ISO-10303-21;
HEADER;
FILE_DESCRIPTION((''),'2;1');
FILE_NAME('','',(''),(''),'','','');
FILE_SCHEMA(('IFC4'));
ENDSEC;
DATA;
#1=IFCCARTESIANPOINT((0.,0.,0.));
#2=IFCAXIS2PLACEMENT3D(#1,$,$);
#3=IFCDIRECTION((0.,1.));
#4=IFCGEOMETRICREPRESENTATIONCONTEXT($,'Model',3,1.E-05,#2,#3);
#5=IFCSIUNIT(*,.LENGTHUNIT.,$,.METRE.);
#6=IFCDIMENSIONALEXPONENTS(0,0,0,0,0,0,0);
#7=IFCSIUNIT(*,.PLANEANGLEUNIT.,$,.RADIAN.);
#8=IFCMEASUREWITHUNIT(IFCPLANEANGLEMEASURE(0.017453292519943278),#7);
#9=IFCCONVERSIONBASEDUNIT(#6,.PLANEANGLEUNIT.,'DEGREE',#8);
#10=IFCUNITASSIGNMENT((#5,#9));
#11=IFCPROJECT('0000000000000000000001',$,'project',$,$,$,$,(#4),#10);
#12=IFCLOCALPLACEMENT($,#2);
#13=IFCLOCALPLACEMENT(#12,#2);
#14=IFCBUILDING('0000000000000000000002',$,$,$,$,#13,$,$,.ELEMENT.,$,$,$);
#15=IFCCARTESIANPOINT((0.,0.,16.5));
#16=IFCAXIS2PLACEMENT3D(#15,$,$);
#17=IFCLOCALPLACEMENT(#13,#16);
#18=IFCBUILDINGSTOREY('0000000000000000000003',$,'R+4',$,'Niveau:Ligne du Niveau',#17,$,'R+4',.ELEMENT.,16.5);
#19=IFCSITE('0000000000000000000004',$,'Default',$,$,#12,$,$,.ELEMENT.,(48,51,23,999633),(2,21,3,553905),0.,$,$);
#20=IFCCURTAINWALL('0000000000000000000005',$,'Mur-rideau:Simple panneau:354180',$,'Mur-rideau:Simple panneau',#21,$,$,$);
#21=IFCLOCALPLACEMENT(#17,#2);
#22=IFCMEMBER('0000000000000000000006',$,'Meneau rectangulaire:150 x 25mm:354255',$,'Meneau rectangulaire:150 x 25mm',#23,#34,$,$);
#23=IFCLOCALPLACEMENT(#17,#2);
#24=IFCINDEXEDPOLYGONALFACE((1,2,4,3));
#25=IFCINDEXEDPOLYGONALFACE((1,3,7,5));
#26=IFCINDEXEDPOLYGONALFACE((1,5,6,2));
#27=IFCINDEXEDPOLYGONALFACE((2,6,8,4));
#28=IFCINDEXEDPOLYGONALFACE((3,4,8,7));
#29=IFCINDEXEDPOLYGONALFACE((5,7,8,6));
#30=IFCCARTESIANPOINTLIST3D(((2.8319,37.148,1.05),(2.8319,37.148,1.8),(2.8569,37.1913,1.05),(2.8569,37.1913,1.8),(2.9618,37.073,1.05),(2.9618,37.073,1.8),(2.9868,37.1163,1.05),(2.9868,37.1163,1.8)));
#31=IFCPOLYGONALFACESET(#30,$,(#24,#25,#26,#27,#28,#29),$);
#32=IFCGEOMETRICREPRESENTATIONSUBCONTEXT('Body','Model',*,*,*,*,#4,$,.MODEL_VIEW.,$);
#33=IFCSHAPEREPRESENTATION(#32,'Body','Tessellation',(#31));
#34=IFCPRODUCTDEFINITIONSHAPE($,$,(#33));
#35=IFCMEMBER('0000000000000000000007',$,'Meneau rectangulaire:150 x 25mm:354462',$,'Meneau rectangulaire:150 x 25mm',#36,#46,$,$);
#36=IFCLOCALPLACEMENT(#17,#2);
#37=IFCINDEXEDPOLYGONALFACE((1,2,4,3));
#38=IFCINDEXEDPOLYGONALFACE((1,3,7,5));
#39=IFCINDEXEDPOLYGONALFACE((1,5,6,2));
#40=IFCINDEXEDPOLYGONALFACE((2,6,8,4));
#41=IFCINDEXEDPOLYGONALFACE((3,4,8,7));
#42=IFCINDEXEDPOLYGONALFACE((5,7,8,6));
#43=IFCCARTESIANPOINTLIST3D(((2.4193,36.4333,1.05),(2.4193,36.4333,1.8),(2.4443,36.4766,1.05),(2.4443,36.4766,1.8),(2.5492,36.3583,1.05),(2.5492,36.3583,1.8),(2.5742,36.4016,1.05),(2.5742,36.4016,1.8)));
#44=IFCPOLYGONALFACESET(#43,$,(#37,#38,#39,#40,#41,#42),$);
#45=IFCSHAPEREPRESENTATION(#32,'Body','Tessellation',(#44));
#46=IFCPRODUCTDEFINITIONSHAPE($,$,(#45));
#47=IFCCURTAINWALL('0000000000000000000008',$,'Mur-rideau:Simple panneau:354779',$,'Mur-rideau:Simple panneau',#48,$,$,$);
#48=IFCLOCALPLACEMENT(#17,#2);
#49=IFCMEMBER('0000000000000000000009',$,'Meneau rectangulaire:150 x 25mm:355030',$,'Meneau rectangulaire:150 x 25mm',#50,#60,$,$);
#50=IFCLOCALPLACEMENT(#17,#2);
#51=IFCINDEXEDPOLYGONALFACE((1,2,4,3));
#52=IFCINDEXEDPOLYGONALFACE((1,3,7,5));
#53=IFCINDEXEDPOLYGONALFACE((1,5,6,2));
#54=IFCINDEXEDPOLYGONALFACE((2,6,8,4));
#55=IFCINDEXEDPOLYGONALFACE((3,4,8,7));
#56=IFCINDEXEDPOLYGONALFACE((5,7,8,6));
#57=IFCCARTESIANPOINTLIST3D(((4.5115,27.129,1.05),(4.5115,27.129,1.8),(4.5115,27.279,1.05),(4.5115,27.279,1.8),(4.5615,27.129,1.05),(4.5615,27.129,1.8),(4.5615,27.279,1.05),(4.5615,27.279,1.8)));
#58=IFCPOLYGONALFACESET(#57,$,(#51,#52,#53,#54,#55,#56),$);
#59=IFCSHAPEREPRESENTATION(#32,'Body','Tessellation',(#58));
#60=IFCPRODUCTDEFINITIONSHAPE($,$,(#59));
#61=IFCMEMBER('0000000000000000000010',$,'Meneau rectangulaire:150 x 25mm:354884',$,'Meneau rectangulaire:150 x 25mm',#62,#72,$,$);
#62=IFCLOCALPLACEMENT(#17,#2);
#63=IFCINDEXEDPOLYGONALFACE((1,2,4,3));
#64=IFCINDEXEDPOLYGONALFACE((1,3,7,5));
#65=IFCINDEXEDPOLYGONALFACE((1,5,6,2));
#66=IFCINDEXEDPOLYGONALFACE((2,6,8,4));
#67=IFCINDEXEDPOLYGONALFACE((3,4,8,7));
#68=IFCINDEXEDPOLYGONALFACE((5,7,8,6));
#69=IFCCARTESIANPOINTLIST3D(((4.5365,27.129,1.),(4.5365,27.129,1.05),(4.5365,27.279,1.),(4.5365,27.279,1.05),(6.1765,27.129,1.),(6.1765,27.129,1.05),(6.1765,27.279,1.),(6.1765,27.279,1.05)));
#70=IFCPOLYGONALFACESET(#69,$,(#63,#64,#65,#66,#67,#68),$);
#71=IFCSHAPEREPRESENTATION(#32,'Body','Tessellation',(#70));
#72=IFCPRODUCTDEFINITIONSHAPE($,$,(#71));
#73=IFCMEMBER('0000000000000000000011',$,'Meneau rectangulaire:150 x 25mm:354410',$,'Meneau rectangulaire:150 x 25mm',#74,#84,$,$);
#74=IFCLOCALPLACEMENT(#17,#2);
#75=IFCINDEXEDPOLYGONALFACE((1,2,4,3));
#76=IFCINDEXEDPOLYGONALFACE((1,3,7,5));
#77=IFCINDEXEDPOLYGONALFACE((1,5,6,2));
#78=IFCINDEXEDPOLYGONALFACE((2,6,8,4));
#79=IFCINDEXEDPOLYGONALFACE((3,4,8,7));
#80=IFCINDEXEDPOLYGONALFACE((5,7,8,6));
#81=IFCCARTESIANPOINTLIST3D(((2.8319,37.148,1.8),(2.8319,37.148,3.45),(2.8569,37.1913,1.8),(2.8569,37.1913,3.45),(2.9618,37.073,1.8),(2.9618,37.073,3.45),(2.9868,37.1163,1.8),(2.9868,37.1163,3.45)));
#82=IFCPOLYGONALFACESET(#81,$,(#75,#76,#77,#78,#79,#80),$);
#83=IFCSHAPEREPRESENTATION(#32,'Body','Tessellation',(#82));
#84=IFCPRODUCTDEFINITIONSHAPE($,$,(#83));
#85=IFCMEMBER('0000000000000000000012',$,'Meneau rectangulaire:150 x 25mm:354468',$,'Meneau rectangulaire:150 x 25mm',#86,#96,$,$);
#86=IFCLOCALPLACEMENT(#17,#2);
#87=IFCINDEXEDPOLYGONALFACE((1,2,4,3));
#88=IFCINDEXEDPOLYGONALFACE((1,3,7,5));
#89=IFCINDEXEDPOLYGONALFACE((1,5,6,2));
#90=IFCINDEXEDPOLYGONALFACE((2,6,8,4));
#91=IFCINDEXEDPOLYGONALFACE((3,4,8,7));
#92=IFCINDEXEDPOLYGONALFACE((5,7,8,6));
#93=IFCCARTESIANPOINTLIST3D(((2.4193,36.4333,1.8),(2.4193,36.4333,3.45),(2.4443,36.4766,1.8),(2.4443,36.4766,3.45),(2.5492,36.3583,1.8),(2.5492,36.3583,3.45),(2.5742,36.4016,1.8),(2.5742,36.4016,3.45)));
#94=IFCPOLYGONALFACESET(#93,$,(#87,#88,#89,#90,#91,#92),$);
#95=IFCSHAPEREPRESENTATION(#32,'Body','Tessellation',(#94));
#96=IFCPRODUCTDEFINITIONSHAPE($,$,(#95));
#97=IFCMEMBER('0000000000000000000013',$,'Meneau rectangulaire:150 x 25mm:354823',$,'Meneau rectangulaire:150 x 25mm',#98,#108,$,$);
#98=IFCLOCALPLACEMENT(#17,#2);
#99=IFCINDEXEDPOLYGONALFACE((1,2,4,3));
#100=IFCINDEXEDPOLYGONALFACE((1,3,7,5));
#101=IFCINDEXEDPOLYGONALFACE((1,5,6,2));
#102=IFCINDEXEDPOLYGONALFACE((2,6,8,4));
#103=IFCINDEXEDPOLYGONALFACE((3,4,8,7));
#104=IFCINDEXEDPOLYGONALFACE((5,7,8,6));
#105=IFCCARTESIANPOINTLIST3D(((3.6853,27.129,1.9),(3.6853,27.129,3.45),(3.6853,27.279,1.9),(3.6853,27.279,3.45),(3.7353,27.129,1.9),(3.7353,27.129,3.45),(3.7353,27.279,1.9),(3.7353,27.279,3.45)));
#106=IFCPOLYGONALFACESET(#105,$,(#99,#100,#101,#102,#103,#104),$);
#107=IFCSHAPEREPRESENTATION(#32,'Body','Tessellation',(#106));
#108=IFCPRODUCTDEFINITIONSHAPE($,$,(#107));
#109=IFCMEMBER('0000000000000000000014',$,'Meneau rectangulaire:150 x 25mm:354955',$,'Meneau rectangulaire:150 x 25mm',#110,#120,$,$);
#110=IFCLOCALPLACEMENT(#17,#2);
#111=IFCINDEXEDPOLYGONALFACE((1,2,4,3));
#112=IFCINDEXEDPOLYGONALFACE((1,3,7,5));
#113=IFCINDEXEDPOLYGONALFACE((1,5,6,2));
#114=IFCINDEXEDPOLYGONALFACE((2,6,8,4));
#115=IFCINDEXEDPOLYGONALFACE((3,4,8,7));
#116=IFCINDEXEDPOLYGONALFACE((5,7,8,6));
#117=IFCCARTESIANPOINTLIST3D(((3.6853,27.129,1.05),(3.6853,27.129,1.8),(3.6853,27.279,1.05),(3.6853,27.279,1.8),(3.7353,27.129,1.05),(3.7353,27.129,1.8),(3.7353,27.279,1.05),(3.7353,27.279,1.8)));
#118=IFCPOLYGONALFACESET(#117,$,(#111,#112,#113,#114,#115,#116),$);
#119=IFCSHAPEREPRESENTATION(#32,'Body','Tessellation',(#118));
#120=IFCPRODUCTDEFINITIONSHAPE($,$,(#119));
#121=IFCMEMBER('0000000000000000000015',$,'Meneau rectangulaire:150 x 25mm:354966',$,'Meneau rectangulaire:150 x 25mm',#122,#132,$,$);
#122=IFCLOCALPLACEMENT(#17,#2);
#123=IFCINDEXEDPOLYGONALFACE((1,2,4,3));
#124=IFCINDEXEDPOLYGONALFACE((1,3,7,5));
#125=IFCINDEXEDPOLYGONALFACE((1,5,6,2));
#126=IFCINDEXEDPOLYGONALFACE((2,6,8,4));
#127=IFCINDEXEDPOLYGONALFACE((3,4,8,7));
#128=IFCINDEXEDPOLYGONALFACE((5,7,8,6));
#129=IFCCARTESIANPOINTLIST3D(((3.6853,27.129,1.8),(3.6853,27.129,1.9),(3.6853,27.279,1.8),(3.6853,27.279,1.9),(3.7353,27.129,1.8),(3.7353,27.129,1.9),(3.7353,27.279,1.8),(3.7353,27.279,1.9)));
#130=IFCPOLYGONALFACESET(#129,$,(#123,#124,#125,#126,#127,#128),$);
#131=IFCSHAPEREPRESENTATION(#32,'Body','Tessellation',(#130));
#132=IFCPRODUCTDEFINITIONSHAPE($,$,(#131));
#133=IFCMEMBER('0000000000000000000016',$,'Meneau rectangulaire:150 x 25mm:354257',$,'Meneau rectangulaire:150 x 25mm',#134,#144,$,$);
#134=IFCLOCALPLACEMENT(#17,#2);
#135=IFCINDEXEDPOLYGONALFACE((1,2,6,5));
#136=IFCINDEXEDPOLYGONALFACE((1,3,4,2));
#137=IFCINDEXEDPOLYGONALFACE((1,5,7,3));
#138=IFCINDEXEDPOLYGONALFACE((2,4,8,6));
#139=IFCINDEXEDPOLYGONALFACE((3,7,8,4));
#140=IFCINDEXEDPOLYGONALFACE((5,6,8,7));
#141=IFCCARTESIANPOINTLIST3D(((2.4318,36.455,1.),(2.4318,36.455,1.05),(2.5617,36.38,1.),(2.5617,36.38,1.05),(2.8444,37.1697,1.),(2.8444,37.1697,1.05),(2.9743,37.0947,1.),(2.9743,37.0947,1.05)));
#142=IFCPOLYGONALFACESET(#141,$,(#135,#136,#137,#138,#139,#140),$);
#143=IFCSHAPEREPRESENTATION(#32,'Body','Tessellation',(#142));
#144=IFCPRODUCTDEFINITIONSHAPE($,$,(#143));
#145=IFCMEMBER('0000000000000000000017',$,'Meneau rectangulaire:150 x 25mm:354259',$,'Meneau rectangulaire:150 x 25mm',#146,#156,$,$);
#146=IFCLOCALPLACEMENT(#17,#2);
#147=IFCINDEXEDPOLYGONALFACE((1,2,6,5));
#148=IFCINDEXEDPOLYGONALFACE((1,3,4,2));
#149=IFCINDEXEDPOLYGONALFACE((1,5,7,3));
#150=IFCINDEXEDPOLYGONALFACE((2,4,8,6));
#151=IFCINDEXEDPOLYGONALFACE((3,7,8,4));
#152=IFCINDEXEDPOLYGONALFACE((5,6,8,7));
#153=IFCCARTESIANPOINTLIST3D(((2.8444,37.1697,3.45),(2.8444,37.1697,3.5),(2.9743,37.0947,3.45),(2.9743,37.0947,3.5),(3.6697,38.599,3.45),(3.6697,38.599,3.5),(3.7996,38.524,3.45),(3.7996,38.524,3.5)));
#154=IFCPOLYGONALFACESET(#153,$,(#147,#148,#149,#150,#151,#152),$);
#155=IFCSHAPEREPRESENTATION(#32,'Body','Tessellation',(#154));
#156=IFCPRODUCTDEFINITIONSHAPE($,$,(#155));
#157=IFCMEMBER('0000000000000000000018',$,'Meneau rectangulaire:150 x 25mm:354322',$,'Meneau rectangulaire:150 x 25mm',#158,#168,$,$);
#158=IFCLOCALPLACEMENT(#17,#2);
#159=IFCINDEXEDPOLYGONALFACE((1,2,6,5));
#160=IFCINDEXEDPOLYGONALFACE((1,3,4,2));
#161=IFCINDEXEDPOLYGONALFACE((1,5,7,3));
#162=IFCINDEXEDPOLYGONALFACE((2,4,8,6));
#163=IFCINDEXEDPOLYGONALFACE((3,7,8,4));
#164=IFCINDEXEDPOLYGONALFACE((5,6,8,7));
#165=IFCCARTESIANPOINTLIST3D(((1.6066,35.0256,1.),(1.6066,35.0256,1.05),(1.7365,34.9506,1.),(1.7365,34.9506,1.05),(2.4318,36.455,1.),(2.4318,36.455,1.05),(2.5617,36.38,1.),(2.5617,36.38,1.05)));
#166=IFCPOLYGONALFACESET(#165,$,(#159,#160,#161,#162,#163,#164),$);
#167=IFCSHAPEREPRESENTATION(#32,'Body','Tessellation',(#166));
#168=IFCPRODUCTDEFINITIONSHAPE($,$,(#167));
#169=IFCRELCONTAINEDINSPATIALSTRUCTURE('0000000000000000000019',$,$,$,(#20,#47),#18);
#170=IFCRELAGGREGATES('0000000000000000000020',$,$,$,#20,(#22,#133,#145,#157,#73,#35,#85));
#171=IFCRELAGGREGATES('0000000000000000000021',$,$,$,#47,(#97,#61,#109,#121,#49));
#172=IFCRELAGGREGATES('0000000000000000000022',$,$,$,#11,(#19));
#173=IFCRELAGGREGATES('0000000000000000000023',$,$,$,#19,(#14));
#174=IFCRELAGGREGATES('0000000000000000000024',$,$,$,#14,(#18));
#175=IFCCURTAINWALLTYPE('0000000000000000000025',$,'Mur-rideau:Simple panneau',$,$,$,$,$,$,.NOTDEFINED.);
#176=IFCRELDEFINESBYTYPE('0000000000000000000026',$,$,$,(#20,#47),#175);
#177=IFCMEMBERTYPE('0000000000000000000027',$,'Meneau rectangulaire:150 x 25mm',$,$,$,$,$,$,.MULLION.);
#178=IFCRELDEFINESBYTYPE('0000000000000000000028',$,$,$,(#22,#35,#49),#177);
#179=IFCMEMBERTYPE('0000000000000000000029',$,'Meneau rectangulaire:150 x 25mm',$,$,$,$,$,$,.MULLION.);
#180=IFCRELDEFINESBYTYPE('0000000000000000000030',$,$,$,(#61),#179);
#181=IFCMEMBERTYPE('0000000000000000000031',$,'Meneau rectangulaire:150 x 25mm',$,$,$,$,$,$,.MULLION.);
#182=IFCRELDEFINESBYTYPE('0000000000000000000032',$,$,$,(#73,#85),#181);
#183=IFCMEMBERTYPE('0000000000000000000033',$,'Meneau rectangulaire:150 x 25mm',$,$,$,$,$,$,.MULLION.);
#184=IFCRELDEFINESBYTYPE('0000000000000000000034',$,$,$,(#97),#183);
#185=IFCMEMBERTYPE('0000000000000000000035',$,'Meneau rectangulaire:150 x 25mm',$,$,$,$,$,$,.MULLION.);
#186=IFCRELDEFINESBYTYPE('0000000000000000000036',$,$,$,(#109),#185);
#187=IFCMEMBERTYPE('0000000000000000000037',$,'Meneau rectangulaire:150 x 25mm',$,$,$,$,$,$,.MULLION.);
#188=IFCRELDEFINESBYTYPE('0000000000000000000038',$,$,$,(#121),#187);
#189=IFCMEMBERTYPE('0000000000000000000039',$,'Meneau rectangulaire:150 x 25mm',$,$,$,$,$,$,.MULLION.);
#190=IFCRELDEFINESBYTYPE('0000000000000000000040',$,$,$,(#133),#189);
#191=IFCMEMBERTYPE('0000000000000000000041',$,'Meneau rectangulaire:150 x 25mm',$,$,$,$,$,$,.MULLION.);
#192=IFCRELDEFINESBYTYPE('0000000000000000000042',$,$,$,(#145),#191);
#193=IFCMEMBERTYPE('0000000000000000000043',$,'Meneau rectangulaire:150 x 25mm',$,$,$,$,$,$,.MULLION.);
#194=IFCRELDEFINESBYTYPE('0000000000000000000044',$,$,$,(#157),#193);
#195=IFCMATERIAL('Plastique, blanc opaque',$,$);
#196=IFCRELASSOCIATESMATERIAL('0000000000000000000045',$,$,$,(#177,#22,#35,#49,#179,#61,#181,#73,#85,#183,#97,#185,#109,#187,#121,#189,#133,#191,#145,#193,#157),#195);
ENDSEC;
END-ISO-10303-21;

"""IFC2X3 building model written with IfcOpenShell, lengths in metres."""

from ifc_helpers import new_model, entity, si_unit, converted_unit, direction, frame, frame_2d, origin, origin_2d_with_axis, place, context, subcontext, project, spatial, rectangle, extrude, source, transform, mapped, material, type_object, type_shapes, element, aggregate, save


model = new_model("IFC2X3")

# Units and contexts
model_context = context("Model", 3, precision=1e-05, world=origin(), true_north=direction((0.0, 1.0)))
body_context = subcontext(model_context, "Body", "Model", "MODEL_VIEW")
ifc_project = project(units=[si_unit("LENGTHUNIT", "METRE"), converted_unit("PLANEANGLEUNIT", "DEGREE", entity("IfcPlaneAngleMeasure", 0.017453292519943278), si_unit("PLANEANGLEUNIT", "RADIAN"), dimensions=[0, 0, 0, 0, 0, 0, 0])], contexts=[model_context])

# Site, building, storey
site_placement = place(None, origin())
site = spatial("IfcSite", under=ifc_project, at=site_placement, Name="Default", CompositionType="ELEMENT", RefLatitude=(48, 51, 23, 999633), RefLongitude=(2, 21, 3, 553905), RefElevation=0.0)
building_placement = place(site_placement, origin())
building = spatial("IfcBuilding", under=site, at=building_placement, CompositionType="ELEMENT")
storey_placement = place(building_placement, frame((0.0, 0.0, 16.5)))
storey = spatial("IfcBuildingStorey", under=building, at=storey_placement, Name="R+4", ObjectType="Niveau:Ligne du Niveau", LongName="R+4", CompositionType="ELEMENT", Elevation=16.5)

# Curtain walls, members
curtain_wall_type = type_object("IfcCurtainWallType", Name="Mur-rideau:Simple panneau", PredefinedType="NOTDEFINED")
curtain_wall_1_placement = place(storey_placement, frame((0.0, 0.0, -16.5)))
curtain_wall_1 = element("IfcCurtainWall", 1, at=curtain_wall_1_placement, inside=storey, type_object=curtain_wall_type, Name="Mur-rideau:Simple panneau:354180", ObjectType="Mur-rideau:Simple panneau")
ifc_material_1 = material(Name="Plastique, blanc opaque")
member_type_1 = type_object("IfcMemberType", Name="Meneau rectangulaire:150 x 25mm", PredefinedType="MULLION", material=ifc_material_1)
shared_shape_1 = source(origin(), body_context, "Body", "SweptSolid", [
    extrude(rectangle(XDim=0.05, YDim=0.15, at=origin_2d_with_axis()), frame((0.0, 0.0, -0.75), z_axis=(0.0, 0.0, 1.0), x_axis=(-1.0, 0.0, 0.0)), (0.0, 0.0, 1.0), 0.75),
])
type_shapes(member_type_1, [shared_shape_1])
member_1_placement = place(curtain_wall_1_placement, frame((2.9094, 37.1322, 17.55), z_axis=(0.0, 0.0, -1.0), x_axis=(-0.5, -0.866025, 0.0)))
member_1 = element("IfcMember", 2, at=member_1_placement, type_object=member_type_1, material=ifc_material_1, Name="Meneau rectangulaire:150 x 25mm:354255", ObjectType="Meneau rectangulaire:150 x 25mm", context=body_context, shape_type="MappedRepresentation", body=[
    mapped(shared_shape_1, transform((0.0, 0.0, 0.0), scale=1.0)),
])
member_2_placement = place(curtain_wall_1_placement, frame((2.4968, 36.4175, 17.55), z_axis=(0.0, 0.0, -1.0), x_axis=(-0.5, -0.866025, 0.0)))
member_2 = element("IfcMember", 3, at=member_2_placement, type_object=member_type_1, material=ifc_material_1, Name="Meneau rectangulaire:150 x 25mm:354462", ObjectType="Meneau rectangulaire:150 x 25mm", context=body_context, shape_type="MappedRepresentation", body=[
    mapped(shared_shape_1, transform((0.0, 0.0, 0.0), scale=1.0)),
])
curtain_wall_2_placement = place(storey_placement, frame((0.0, 0.0, -16.5)))
curtain_wall_2 = element("IfcCurtainWall", 4, at=curtain_wall_2_placement, inside=storey, type_object=curtain_wall_type, Name="Mur-rideau:Simple panneau:354779", ObjectType="Mur-rideau:Simple panneau")
member_3_placement = place(curtain_wall_2_placement, frame((4.5365, 27.204, 17.55), z_axis=(0.0, 0.0, -1.0), x_axis=(1.0, 0.0, 0.0)))
member_3 = element("IfcMember", 5, at=member_3_placement, type_object=member_type_1, material=ifc_material_1, Name="Meneau rectangulaire:150 x 25mm:355030", ObjectType="Meneau rectangulaire:150 x 25mm", context=body_context, shape_type="MappedRepresentation", body=[
    mapped(shared_shape_1, transform((0.0, 0.0, 0.0), scale=1.0)),
])
member_type_2 = type_object("IfcMemberType", Name="Meneau rectangulaire:150 x 25mm", PredefinedType="MULLION", material=ifc_material_1)
shared_shape_2 = source(origin(), body_context, "Body", "SweptSolid", [
    extrude(rectangle(XDim=0.05, YDim=0.15, at=origin_2d_with_axis()), frame((-0.025, 0.0, -1.64), z_axis=(0.0, 0.0, 1.0), x_axis=(-1.0, 0.0, 0.0)), (0.0, 0.0, 1.0), 1.64),
])
type_shapes(member_type_2, [shared_shape_2])
member_4_placement = place(curtain_wall_2_placement, frame((4.5365, 27.204, 17.5), z_axis=(-1.0, 0.0, 0.0), x_axis=(0.0, 0.0, -1.0)))
member_4 = element("IfcMember", 6, at=member_4_placement, type_object=member_type_2, material=ifc_material_1, Name="Meneau rectangulaire:150 x 25mm:354884", ObjectType="Meneau rectangulaire:150 x 25mm", context=body_context, shape_type="MappedRepresentation", body=[
    mapped(shared_shape_2, transform((0.0, 0.0, 0.0), scale=1.0)),
])

# Members
member_type_3 = type_object("IfcMemberType", Name="Meneau rectangulaire:150 x 25mm", PredefinedType="MULLION", material=ifc_material_1)
shared_shape_3 = source(origin(), body_context, "Body", "SweptSolid", [
    extrude(rectangle(XDim=0.05, YDim=0.15, at=origin_2d_with_axis()), frame((0.0, 0.0, -1.65), z_axis=(0.0, 0.0, 1.0), x_axis=(-1.0, 0.0, 0.0)), (0.0, 0.0, 1.0), 1.65),
])
type_shapes(member_type_3, [shared_shape_3])
member_5_placement = place(curtain_wall_1_placement, frame((2.9094, 37.1322, 18.3), z_axis=(0.0, 0.0, -1.0), x_axis=(-0.5, -0.866025, 0.0)))
member_5 = element("IfcMember", 7, at=member_5_placement, type_object=member_type_3, material=ifc_material_1, Name="Meneau rectangulaire:150 x 25mm:354410", ObjectType="Meneau rectangulaire:150 x 25mm", context=body_context, shape_type="MappedRepresentation", body=[
    mapped(shared_shape_3, transform((0.0, 0.0, 0.0), scale=1.0)),
])
member_6_placement = place(curtain_wall_1_placement, frame((2.4968, 36.4175, 18.3), z_axis=(0.0, 0.0, -1.0), x_axis=(-0.5, -0.866025, 0.0)))
member_6 = element("IfcMember", 8, at=member_6_placement, type_object=member_type_3, material=ifc_material_1, Name="Meneau rectangulaire:150 x 25mm:354468", ObjectType="Meneau rectangulaire:150 x 25mm", context=body_context, shape_type="MappedRepresentation", body=[
    mapped(shared_shape_3, transform((0.0, 0.0, 0.0), scale=1.0)),
])
member_type_4 = type_object("IfcMemberType", Name="Meneau rectangulaire:150 x 25mm", PredefinedType="MULLION", material=ifc_material_1)
shared_shape_4 = source(origin(), body_context, "Body", "SweptSolid", [
    extrude(rectangle(XDim=0.05, YDim=0.15, at=origin_2d_with_axis()), frame((-0.025, 0.0, -1.55), z_axis=(0.0, 0.0, 1.0), x_axis=(-1.0, 0.0, 0.0)), (0.0, 0.0, 1.0), 1.55),
])
type_shapes(member_type_4, [shared_shape_4])
member_7_placement = place(curtain_wall_2_placement, frame((3.6853, 27.204, 19.95), z_axis=(0.0, 0.0, 1.0), x_axis=(-1.0, 0.0, 0.0)))
member_7 = element("IfcMember", 9, at=member_7_placement, type_object=member_type_4, material=ifc_material_1, Name="Meneau rectangulaire:150 x 25mm:354823", ObjectType="Meneau rectangulaire:150 x 25mm", context=body_context, shape_type="MappedRepresentation", body=[
    mapped(shared_shape_4, transform((0.0, 0.0, 0.0), scale=1.0)),
])
member_type_5 = type_object("IfcMemberType", Name="Meneau rectangulaire:150 x 25mm", PredefinedType="MULLION", material=ifc_material_1)
shared_shape_5 = source(origin(), body_context, "Body", "SweptSolid", [
    extrude(rectangle(XDim=0.05, YDim=0.15, at=origin_2d_with_axis()), frame((-0.025, 0.0, -0.75), z_axis=(0.0, 0.0, 1.0), x_axis=(-1.0, 0.0, 0.0)), (0.0, 0.0, 1.0), 0.75),
])
type_shapes(member_type_5, [shared_shape_5])
member_8_placement = place(curtain_wall_2_placement, frame((3.6853, 27.204, 18.3), z_axis=(0.0, 0.0, 1.0), x_axis=(-1.0, 0.0, 0.0)))
member_8 = element("IfcMember", 10, at=member_8_placement, type_object=member_type_5, material=ifc_material_1, Name="Meneau rectangulaire:150 x 25mm:354955", ObjectType="Meneau rectangulaire:150 x 25mm", context=body_context, shape_type="MappedRepresentation", body=[
    mapped(shared_shape_5, transform((0.0, 0.0, 0.0), scale=1.0)),
])
member_type_6 = type_object("IfcMemberType", Name="Meneau rectangulaire:150 x 25mm", PredefinedType="MULLION", material=ifc_material_1)
shared_shape_6 = source(origin(), body_context, "Body", "SweptSolid", [
    extrude(rectangle(XDim=0.05, YDim=0.15, at=origin_2d_with_axis()), frame((-0.025, 0.0, -0.1), z_axis=(0.0, 0.0, 1.0), x_axis=(-1.0, 0.0, 0.0)), (0.0, 0.0, 1.0), 0.1),
])
type_shapes(member_type_6, [shared_shape_6])
member_9_placement = place(curtain_wall_2_placement, frame((3.6853, 27.204, 18.4), z_axis=(0.0, 0.0, 1.0), x_axis=(-1.0, 0.0, 0.0)))
member_9 = element("IfcMember", 11, at=member_9_placement, type_object=member_type_6, material=ifc_material_1, Name="Meneau rectangulaire:150 x 25mm:354966", ObjectType="Meneau rectangulaire:150 x 25mm", context=body_context, shape_type="MappedRepresentation", body=[
    mapped(shared_shape_6, transform((0.0, 0.0, 0.0), scale=1.0)),
])
member_type_7 = type_object("IfcMemberType", Name="Meneau rectangulaire:150 x 25mm", PredefinedType="MULLION", material=ifc_material_1)
shared_shape_7 = source(origin(), body_context, "Body", "SweptSolid", [
    extrude(rectangle(XDim=0.05, YDim=0.15, at=origin_2d_with_axis()), frame((-0.025, 0.0, -0.8253), z_axis=(0.0, 0.0, 1.0), x_axis=(-1.0, 0.0, 0.0)), (0.0, 0.0, 1.0), 0.8253),
])
type_shapes(member_type_7, [shared_shape_7])
member_10_placement = place(curtain_wall_1_placement, frame((2.9094, 37.1322, 17.5), z_axis=(0.5, 0.866025, 0.0), x_axis=(0.0, 0.0, -1.0)))
member_10 = element("IfcMember", 12, at=member_10_placement, type_object=member_type_7, material=ifc_material_1, Name="Meneau rectangulaire:150 x 25mm:354257", ObjectType="Meneau rectangulaire:150 x 25mm", context=body_context, shape_type="MappedRepresentation", body=[
    mapped(shared_shape_7, transform((0.0, 0.0, 0.0), scale=1.0)),
])
member_type_8 = type_object("IfcMemberType", Name="Meneau rectangulaire:150 x 25mm", PredefinedType="MULLION", material=ifc_material_1)
shared_shape_8 = source(origin(), body_context, "Body", "SweptSolid", [
    extrude(rectangle(XDim=0.05, YDim=0.15, at=origin_2d_with_axis()), frame((-0.025, 0.0, -1.6505), z_axis=(0.0, 0.0, 1.0), x_axis=(-1.0, 0.0, 0.0)), (0.0, 0.0, 1.0), 1.6505),
])
type_shapes(member_type_8, [shared_shape_8])
member_11_placement = place(curtain_wall_1_placement, frame((2.9094, 37.1322, 20.0), z_axis=(-0.5, -0.866025, 0.0), x_axis=(0.0, 0.0, 1.0)))
member_11 = element("IfcMember", 13, at=member_11_placement, type_object=member_type_8, material=ifc_material_1, Name="Meneau rectangulaire:150 x 25mm:354259", ObjectType="Meneau rectangulaire:150 x 25mm", context=body_context, shape_type="MappedRepresentation", body=[
    mapped(shared_shape_8, transform((0.0, 0.0, 0.0), scale=1.0)),
])
member_type_9 = type_object("IfcMemberType", Name="Meneau rectangulaire:150 x 25mm", PredefinedType="MULLION", material=ifc_material_1)
shared_shape_9 = source(origin(), body_context, "Body", "SweptSolid", [
    extrude(rectangle(XDim=0.05, YDim=0.15, at=frame_2d((0.0, 0.0), x_axis=(1.0, 0.0))), frame((-0.025, 0.0, -1.6505), z_axis=(0.0, 0.0, 1.0), x_axis=(-1.0, 0.0, 0.0)), (0.0, 0.0, 1.0), 1.6505),
])
type_shapes(member_type_9, [shared_shape_9])
member_12_placement = place(curtain_wall_1_placement, frame((2.4968, 36.4175, 17.5), z_axis=(0.5, 0.866025, 0.0), x_axis=(0.0, 0.0, -1.0)))
member_12 = element("IfcMember", 14, at=member_12_placement, type_object=member_type_9, material=ifc_material_1, Name="Meneau rectangulaire:150 x 25mm:354322", ObjectType="Meneau rectangulaire:150 x 25mm", context=body_context, shape_type="MappedRepresentation", body=[
    mapped(shared_shape_9, transform((0.0, 0.0, 0.0), scale=1.0)),
])

aggregate(curtain_wall_1, [member_1, member_10, member_11, member_12, member_5, member_2, member_6])
aggregate(curtain_wall_2, [member_7, member_4, member_8, member_9, member_3])

save(model, "model.ifc")
